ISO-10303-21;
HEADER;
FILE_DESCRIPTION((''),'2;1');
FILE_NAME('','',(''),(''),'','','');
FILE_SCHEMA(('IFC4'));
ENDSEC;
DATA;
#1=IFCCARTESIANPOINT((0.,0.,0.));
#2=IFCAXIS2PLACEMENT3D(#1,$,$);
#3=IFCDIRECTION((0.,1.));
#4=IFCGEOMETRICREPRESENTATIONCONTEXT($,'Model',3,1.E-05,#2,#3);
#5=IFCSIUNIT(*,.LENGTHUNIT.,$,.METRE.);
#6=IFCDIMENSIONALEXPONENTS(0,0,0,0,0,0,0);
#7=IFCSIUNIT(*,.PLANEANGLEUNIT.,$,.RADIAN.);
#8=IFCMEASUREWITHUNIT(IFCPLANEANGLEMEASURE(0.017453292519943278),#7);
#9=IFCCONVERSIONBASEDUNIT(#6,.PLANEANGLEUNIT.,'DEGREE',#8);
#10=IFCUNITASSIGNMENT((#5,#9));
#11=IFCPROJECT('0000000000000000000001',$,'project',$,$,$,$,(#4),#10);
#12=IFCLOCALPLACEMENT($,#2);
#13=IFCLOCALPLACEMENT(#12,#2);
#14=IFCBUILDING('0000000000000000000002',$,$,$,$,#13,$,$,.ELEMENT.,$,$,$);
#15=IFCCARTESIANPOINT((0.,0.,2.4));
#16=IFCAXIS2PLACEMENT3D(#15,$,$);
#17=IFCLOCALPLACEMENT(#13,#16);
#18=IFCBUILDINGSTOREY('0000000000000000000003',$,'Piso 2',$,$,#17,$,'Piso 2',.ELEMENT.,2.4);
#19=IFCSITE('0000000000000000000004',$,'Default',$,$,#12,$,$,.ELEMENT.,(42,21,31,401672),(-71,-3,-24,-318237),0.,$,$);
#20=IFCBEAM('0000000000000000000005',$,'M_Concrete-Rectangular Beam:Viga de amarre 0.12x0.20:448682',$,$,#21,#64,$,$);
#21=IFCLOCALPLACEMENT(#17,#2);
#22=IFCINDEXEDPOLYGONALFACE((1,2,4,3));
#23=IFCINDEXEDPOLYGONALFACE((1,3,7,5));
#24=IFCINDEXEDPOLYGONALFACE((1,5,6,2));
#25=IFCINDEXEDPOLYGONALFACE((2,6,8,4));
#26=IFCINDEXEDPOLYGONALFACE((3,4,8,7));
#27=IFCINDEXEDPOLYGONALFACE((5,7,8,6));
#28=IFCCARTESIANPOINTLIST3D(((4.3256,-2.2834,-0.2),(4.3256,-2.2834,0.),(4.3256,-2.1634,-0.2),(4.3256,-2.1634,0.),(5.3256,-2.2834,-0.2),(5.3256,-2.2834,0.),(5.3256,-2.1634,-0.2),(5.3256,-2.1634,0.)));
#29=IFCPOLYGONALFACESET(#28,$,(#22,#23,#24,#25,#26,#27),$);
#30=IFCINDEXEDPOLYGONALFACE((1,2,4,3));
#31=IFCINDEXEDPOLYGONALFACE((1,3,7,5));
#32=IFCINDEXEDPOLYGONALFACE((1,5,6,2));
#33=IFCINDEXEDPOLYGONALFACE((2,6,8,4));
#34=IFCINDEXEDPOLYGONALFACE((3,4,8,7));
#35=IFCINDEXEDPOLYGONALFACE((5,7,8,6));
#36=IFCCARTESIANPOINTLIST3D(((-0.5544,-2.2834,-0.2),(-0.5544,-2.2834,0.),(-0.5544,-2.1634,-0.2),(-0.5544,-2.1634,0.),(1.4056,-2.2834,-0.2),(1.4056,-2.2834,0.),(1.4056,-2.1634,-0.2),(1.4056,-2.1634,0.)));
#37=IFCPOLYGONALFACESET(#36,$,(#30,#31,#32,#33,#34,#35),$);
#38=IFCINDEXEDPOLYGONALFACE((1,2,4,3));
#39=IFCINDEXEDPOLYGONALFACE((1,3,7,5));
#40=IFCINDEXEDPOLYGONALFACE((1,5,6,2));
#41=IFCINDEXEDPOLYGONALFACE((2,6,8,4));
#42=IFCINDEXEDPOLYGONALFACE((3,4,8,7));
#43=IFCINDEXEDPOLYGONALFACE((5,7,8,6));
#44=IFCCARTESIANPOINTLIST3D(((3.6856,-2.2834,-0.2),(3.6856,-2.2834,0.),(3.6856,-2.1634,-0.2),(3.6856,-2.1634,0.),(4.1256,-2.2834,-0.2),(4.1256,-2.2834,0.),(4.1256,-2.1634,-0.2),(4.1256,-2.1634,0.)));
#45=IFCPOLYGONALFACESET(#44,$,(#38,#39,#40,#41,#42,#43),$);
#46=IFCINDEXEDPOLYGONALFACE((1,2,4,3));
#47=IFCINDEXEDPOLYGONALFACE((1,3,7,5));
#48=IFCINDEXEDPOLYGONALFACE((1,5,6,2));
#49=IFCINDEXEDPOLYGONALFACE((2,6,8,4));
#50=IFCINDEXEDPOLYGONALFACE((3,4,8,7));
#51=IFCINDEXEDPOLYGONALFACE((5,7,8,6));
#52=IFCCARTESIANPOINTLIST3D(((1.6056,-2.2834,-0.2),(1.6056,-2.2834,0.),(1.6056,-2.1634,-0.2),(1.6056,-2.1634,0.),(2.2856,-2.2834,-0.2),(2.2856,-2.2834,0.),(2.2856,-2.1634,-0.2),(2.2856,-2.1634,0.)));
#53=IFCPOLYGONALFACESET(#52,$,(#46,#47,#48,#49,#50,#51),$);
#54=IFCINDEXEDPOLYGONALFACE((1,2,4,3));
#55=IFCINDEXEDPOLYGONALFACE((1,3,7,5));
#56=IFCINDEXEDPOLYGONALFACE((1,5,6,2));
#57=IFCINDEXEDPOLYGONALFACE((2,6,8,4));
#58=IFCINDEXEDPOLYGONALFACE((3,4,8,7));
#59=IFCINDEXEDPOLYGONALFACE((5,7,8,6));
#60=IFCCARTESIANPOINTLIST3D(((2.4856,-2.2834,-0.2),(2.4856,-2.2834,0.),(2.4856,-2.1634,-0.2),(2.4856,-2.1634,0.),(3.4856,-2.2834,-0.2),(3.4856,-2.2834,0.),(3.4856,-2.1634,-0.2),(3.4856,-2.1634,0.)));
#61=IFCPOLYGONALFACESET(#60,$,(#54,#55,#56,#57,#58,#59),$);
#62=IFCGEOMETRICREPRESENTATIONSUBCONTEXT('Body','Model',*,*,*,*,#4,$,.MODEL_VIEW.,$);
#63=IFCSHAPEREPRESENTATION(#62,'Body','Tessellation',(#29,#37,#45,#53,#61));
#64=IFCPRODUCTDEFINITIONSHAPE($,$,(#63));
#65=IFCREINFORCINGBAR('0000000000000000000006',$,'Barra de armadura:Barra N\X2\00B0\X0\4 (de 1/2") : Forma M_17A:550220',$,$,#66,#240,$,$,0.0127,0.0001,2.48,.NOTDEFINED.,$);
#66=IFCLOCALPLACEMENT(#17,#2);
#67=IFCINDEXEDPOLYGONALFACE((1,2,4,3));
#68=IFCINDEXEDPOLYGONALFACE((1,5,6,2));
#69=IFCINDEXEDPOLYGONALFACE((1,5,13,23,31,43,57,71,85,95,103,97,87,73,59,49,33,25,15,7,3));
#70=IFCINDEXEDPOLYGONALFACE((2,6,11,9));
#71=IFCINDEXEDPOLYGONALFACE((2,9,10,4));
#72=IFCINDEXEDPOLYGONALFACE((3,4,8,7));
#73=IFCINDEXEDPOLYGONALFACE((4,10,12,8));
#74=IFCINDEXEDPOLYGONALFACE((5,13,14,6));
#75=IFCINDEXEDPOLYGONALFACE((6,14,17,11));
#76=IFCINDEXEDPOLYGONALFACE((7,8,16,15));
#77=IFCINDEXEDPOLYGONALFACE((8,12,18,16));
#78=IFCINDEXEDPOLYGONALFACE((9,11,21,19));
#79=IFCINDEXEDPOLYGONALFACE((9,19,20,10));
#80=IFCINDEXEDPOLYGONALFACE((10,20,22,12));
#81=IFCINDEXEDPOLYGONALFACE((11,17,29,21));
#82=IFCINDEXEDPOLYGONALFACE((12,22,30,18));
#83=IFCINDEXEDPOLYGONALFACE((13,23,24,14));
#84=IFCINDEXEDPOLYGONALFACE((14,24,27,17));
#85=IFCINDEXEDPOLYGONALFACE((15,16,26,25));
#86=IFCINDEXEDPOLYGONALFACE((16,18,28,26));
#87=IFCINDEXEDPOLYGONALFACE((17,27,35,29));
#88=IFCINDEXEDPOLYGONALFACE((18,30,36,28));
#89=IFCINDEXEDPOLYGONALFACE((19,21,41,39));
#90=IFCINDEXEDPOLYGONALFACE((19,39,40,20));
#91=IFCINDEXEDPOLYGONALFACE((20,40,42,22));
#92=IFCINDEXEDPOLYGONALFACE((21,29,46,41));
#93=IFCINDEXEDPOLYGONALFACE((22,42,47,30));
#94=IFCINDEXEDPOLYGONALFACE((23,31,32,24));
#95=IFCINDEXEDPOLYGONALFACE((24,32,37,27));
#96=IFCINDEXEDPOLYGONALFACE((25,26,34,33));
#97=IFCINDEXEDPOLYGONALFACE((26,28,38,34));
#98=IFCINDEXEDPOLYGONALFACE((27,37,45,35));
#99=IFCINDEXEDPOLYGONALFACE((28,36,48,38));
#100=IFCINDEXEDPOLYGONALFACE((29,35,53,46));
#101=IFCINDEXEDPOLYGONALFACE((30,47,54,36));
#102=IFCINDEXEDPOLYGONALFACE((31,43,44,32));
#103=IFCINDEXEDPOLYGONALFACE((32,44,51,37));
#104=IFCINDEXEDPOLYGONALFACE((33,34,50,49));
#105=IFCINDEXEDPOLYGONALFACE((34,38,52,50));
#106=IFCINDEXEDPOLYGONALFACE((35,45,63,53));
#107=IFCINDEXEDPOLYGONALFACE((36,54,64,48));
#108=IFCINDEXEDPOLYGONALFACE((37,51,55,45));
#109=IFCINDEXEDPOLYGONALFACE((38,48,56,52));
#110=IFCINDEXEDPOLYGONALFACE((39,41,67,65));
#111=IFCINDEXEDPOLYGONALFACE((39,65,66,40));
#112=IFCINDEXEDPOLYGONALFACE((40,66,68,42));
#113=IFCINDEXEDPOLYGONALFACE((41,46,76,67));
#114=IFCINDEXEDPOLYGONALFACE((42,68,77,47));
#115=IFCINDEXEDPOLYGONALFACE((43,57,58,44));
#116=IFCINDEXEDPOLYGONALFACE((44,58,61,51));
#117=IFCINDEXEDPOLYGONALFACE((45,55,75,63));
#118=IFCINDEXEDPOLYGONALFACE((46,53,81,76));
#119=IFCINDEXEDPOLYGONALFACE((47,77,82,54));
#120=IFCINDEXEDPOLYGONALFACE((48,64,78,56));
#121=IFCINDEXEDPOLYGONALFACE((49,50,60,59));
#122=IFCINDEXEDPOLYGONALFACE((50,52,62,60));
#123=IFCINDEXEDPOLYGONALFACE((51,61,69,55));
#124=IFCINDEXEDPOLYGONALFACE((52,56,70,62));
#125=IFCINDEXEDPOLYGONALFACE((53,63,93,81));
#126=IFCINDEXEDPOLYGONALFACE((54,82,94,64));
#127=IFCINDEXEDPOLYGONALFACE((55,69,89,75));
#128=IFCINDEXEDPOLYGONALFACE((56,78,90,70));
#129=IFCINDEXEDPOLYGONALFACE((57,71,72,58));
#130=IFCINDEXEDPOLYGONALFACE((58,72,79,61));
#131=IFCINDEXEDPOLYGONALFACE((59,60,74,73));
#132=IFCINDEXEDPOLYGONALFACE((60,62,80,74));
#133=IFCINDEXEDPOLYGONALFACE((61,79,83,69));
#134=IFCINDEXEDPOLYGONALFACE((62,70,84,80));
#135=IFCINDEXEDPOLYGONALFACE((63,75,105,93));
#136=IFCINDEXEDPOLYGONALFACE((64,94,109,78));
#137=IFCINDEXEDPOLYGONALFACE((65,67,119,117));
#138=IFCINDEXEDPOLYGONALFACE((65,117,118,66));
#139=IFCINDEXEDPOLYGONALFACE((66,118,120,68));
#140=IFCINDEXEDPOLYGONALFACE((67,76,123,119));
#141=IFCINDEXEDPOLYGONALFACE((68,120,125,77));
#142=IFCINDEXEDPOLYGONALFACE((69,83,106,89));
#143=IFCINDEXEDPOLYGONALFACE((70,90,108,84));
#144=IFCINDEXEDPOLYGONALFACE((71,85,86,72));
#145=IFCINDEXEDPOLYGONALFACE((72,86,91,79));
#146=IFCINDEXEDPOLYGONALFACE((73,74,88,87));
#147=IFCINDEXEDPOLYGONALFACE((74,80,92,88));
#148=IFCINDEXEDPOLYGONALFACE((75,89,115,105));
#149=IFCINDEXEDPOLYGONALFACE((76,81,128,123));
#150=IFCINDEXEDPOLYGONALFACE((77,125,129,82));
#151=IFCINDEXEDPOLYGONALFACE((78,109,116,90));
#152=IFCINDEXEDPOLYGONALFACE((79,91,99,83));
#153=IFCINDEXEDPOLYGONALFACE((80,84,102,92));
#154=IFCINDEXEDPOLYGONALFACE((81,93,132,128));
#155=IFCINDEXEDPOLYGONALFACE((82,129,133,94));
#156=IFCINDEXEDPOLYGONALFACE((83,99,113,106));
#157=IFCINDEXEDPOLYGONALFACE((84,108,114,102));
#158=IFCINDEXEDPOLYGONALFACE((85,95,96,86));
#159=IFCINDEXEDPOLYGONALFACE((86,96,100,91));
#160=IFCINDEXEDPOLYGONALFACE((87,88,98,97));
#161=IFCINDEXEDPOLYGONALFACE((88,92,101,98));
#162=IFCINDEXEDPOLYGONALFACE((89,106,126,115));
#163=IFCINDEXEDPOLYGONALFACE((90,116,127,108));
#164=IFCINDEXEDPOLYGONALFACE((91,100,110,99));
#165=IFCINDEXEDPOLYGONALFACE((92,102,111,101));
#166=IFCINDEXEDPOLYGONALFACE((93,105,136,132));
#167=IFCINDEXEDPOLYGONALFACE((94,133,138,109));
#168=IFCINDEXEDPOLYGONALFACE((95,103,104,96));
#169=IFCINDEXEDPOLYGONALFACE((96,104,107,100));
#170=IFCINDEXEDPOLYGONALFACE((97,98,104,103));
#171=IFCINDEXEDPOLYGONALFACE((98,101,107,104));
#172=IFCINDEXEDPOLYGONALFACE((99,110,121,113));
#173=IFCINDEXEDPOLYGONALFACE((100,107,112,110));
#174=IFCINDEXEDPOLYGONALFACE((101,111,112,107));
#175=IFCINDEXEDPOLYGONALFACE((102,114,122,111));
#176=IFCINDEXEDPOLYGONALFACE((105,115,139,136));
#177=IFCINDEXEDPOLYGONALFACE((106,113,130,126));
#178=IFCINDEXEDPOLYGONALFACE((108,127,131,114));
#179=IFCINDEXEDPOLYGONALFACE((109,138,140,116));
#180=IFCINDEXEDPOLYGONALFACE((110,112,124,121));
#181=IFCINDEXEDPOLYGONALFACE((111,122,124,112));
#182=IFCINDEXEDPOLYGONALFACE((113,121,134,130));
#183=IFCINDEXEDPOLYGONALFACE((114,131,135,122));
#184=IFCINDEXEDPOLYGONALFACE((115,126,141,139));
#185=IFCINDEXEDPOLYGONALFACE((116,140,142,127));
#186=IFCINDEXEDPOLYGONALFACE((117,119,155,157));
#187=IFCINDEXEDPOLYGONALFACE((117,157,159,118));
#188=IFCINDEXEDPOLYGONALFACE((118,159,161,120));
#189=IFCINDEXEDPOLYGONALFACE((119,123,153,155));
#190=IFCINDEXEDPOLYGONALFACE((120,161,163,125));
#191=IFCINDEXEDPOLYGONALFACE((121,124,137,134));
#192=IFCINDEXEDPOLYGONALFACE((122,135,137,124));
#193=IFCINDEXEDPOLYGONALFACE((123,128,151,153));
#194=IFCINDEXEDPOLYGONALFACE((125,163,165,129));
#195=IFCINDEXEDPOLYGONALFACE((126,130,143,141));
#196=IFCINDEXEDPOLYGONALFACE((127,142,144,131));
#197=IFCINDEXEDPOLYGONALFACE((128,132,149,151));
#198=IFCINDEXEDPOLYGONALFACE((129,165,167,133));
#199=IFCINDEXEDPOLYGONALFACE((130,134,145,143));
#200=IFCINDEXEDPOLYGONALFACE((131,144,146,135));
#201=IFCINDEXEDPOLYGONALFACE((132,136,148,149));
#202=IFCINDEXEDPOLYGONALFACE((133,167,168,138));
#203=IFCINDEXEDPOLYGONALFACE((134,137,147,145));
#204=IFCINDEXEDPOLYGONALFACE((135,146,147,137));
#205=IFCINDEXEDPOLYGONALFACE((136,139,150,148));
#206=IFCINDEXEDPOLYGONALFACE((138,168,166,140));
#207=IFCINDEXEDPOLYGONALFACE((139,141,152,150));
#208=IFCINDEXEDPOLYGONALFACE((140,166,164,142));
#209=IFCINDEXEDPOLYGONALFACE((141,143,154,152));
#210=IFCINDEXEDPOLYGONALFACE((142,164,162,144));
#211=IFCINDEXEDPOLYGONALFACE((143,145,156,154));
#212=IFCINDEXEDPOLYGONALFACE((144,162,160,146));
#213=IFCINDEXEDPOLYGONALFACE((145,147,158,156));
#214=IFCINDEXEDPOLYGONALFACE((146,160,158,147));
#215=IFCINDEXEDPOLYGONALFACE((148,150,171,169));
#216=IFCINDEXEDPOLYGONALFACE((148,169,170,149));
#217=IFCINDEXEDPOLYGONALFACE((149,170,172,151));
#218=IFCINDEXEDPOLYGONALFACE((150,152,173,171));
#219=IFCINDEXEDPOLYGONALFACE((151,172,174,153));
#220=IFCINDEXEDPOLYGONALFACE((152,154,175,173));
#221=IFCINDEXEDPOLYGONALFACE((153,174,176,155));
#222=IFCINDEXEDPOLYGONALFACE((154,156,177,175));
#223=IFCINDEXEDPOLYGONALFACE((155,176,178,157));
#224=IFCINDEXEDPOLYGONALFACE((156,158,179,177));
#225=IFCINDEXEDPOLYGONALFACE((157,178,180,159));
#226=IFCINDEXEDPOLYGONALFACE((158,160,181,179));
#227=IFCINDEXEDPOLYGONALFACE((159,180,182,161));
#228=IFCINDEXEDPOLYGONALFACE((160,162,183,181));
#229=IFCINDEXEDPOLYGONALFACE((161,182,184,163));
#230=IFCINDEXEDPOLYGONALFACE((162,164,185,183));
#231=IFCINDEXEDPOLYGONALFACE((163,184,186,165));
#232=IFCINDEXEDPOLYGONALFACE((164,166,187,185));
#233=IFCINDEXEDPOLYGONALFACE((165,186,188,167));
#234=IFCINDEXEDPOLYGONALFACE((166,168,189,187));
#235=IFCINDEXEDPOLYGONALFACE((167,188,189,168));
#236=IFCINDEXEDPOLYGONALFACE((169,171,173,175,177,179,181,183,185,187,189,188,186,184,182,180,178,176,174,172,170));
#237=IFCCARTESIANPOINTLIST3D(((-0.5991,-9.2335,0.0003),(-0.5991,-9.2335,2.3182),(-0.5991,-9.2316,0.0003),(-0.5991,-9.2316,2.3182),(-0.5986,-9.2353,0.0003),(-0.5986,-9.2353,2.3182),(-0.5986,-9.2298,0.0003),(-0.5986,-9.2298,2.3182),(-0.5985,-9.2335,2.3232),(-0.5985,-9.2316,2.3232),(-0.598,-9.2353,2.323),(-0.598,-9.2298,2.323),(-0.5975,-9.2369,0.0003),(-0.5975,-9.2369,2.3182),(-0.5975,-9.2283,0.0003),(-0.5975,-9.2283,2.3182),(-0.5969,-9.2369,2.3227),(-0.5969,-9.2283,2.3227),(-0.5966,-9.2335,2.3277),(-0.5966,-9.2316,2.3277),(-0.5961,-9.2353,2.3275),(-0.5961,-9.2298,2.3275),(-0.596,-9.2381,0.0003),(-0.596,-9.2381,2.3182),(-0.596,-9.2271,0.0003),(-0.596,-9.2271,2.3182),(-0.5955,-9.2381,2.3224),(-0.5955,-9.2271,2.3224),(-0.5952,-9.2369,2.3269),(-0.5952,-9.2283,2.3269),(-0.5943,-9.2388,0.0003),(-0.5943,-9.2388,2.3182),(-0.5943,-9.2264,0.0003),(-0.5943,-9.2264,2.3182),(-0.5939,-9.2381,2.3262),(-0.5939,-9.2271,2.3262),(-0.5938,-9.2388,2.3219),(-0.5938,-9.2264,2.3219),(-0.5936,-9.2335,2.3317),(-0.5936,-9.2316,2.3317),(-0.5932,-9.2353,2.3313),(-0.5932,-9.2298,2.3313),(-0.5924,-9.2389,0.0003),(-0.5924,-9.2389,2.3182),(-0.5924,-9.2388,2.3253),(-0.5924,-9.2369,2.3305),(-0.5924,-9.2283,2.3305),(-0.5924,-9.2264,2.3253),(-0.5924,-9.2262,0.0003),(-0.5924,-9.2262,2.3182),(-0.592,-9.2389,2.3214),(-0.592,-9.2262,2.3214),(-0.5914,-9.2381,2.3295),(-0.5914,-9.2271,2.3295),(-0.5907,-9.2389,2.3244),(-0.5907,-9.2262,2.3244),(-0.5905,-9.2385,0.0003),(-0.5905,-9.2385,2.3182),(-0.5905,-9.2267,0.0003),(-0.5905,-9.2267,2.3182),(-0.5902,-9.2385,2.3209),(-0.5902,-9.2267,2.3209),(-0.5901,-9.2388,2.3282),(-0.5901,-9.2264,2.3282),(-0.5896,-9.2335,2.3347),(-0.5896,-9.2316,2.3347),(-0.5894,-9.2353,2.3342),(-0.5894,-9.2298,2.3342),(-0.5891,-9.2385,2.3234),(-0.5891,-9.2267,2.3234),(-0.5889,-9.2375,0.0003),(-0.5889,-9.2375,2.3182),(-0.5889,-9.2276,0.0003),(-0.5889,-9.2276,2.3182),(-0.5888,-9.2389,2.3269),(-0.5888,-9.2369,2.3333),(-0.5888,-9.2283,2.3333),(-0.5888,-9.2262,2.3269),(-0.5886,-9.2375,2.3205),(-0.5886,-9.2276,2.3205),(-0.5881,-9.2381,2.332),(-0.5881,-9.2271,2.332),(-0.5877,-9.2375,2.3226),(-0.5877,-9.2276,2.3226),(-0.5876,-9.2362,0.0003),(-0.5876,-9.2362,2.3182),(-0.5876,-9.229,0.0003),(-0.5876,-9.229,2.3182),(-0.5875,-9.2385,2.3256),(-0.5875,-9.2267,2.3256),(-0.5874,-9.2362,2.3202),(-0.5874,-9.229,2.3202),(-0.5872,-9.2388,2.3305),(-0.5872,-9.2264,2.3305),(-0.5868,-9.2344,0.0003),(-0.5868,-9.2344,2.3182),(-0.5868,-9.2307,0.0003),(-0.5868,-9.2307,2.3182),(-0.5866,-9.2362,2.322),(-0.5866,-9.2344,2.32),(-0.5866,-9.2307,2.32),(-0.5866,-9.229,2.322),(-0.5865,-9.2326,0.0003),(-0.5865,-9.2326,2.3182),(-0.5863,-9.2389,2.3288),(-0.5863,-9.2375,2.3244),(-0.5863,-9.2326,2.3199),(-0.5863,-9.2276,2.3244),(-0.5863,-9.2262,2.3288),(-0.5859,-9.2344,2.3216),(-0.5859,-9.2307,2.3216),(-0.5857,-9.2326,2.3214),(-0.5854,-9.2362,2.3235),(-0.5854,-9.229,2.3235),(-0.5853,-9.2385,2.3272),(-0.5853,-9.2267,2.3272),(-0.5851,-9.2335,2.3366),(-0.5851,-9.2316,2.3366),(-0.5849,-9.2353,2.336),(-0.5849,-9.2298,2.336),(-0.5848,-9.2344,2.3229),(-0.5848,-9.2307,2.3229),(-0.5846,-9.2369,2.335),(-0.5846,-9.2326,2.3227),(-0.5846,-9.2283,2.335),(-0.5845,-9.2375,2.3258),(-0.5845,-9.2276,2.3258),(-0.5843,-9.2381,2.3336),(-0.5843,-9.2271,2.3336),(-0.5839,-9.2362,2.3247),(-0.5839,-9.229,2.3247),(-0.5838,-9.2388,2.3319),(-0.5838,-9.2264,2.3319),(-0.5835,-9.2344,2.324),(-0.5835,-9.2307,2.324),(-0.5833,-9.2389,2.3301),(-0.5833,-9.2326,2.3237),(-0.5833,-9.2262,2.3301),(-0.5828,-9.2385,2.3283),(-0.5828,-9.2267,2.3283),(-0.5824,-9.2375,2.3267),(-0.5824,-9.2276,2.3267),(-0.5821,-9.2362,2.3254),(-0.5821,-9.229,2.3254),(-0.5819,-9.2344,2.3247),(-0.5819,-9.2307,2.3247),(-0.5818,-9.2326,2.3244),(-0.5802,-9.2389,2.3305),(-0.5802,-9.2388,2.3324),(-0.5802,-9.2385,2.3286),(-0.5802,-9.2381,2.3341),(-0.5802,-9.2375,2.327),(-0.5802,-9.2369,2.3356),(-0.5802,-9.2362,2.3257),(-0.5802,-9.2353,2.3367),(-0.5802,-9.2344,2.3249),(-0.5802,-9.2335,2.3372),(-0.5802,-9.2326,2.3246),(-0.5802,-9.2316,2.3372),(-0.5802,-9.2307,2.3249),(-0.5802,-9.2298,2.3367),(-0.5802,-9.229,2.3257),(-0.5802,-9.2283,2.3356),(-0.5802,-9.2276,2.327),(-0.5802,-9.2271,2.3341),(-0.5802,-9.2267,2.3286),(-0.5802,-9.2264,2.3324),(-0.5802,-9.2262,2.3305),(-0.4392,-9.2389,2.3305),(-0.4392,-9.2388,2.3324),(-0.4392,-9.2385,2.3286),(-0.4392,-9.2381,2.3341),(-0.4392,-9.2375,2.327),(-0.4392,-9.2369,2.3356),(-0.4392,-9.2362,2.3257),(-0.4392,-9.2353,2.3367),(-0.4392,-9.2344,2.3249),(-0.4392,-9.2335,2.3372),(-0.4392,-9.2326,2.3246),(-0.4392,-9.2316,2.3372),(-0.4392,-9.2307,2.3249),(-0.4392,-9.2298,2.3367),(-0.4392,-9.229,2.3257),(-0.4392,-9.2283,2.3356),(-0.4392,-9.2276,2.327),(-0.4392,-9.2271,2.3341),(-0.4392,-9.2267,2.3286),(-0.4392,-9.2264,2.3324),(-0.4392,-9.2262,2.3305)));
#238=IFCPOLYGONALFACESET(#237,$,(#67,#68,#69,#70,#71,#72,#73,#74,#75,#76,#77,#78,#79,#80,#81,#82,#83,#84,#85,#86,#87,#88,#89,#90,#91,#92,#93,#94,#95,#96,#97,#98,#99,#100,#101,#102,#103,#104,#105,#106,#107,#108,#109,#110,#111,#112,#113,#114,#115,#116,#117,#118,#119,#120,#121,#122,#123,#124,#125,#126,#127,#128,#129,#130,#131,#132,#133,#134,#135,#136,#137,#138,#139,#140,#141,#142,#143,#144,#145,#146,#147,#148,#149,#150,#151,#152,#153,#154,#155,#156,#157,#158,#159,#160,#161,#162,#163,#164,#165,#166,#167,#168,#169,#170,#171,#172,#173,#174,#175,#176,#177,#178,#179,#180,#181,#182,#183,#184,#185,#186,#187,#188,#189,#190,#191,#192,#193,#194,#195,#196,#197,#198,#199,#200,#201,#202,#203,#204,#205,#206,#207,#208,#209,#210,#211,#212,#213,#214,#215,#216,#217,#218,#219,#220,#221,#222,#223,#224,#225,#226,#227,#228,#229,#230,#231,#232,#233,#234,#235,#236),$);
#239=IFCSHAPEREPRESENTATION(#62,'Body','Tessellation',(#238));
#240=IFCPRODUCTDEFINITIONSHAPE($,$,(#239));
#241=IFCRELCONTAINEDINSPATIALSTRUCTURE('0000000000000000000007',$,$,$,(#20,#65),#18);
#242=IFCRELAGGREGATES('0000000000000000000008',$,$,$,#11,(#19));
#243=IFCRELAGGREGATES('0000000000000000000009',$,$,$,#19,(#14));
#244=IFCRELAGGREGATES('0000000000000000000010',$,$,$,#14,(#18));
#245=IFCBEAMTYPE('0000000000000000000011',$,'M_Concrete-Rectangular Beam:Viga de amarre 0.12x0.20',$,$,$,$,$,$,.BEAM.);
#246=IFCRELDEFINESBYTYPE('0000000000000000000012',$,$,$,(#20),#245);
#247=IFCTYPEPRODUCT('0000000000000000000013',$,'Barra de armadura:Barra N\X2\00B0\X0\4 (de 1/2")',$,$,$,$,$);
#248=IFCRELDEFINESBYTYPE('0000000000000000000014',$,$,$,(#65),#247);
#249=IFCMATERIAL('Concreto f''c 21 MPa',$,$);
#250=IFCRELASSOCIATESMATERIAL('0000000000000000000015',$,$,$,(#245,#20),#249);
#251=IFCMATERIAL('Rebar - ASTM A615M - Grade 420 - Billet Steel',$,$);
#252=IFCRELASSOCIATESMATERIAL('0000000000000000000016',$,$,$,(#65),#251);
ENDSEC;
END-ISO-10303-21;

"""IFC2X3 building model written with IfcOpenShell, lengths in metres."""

from ifc_helpers import new_model, entity, si_unit, converted_unit, direction, frame, frame_2d, origin, place, context, subcontext, project, spatial, rectangle, extrude, source, transform, mapped, material, type_object, type_shapes, element, save


model = new_model("IFC2X3")

# Units and contexts
model_context = context("Model", 3, precision=1e-05, world=origin(), true_north=direction((0.0, 1.0)))
body_context = subcontext(model_context, "Body", "Model", "MODEL_VIEW")
ifc_project = project(units=[si_unit("LENGTHUNIT", "METRE"), converted_unit("PLANEANGLEUNIT", "DEGREE", entity("IfcPlaneAngleMeasure", 0.017453292519943278), si_unit("PLANEANGLEUNIT", "RADIAN"), dimensions=[0, 0, 0, 0, 0, 0, 0])], contexts=[model_context])

# Site, building, storey
site_placement = place(None, origin())
site = spatial("IfcSite", under=ifc_project, at=site_placement, Name="Default", CompositionType="ELEMENT", RefLatitude=(42, 21, 31, 401672), RefLongitude=(-71, -3, -24, -318237), RefElevation=0.0)
building_placement = place(site_placement, origin())
building = spatial("IfcBuilding", under=site, at=building_placement, CompositionType="ELEMENT")
storey_placement = place(building_placement, frame((0.0, 0.0, 2.4)))
storey = spatial("IfcBuildingStorey", under=building, at=storey_placement, Name="Piso 2", LongName="Piso 2", CompositionType="ELEMENT", Elevation=2.4)

# Shared definitions
ifc_material_1 = material(Name="Concreto f'c 21 MPa")

# Beam
beam_type_1 = type_object("IfcBeamType", Name="M_Concrete-Rectangular Beam:Viga de amarre 0.12x0.20", PredefinedType="BEAM", material=ifc_material_1)
shared_shape_1 = source(origin(), body_context, "Body", "SweptSolid", [
    extrude(rectangle(XDim=0.2, YDim=0.12, at=frame_2d((0.0, 0.0), x_axis=(1.0, 0.0))), frame((4.3256, -2.2234, 2.3), z_axis=(1.0, 0.0, 0.0), x_axis=(0.0, 0.0, -1.0)), (0.0, 0.0, 1.0), 1.0),
    extrude(rectangle(XDim=0.2, YDim=0.12, at=frame_2d((0.0, 0.0), x_axis=(1.0, 0.0))), frame((-0.5544, -2.2234, 2.3), z_axis=(1.0, 0.0, 0.0), x_axis=(0.0, 0.0, -1.0)), (0.0, 0.0, 1.0), 1.96),
    extrude(rectangle(XDim=0.2, YDim=0.12, at=frame_2d((0.0, 0.0), x_axis=(1.0, 0.0))), frame((3.6856, -2.2234, 2.3), z_axis=(1.0, 0.0, 0.0), x_axis=(0.0, 0.0, -1.0)), (0.0, 0.0, 1.0), 0.44),
    extrude(rectangle(XDim=0.2, YDim=0.12, at=frame_2d((0.0, 0.0), x_axis=(1.0, 0.0))), frame((1.6056, -2.2234, 2.3), z_axis=(1.0, 0.0, 0.0), x_axis=(0.0, 0.0, -1.0)), (0.0, 0.0, 1.0), 0.68),
    extrude(rectangle(XDim=0.2, YDim=0.12, at=frame_2d((0.0, 0.0), x_axis=(1.0, 0.0))), frame((2.4856, -2.2234, 2.3), z_axis=(1.0, 0.0, 0.0), x_axis=(0.0, 0.0, -1.0)), (0.0, 0.0, 1.0), 1.0),
])
type_shapes(beam_type_1, [shared_shape_1])
beam_1_placement = place(storey_placement, frame((0.0, 0.0, -2.4)))
element("IfcBeam", 1, at=beam_1_placement, inside=storey, type_object=beam_type_1, material=ifc_material_1, Name="M_Concrete-Rectangular Beam:Viga de amarre 0.12x0.20:448682", context=body_context, shape_type="MappedRepresentation", body=[
    mapped(shared_shape_1, transform((0.0, 0.0, 0.0), scale=1.0)),
])

# Reinforcing bar
ifc_material_2 = material(Name="Rebar - ASTM A615M - Grade 420 - Billet Steel")
type_product = type_object("IfcTypeProduct", Name="Barra de armadura:Barra N°4 (de 1/2\")")
reinforcing_bar_1_placement = place(storey_placement, origin())
element("IfcReinforcingBar", 2, at=reinforcing_bar_1_placement, inside=storey, type_object=type_product, material=ifc_material_2, Name="Barra de armadura:Barra N°4 (de 1/2\") : Forma M_17A:550220", BarLength=2.48, BarRole="NOTDEFINED", CrossSectionArea=0.0001, NominalDiameter=0.0127, context=body_context, shape_type="AdvancedSweptSolid", body=[
    entity("IfcSweptDiskSolid", entity("IfcCompositeCurve", [entity("IfcCompositeCurveSegment", "CONTINUOUS", True, entity("IfcPolyline", [entity("IfcCartesianPoint", [-0.5929, -9.2326, 0.0003]), entity("IfcCartesianPoint", [-0.5929, -9.2326, 2.3182])])), entity("IfcCompositeCurveSegment", "CONTINUOUS", True, entity("IfcTrimmedCurve", entity("IfcCircle", entity("IfcAxis2Placement3D", entity("IfcCartesianPoint", [-0.5802, -9.2326, 2.3182]), entity("IfcDirection", [0.0, 1.0, 0.0]), entity("IfcDirection", [0.0, 0.0, 1.0])), 0.0127), [entity("IfcParameterValue", 270.0)], [entity("IfcParameterValue", 360.0)], True, "PARAMETER")), entity("IfcCompositeCurveSegment", "CONTINUOUS", True, entity("IfcPolyline", [entity("IfcCartesianPoint", [-0.5802, -9.2326, 2.3309]), entity("IfcCartesianPoint", [-0.4392, -9.2326, 2.3309])]))], False), 0.0063, None, 0.0, 92.0),
])

save(model, "model.ifc")
